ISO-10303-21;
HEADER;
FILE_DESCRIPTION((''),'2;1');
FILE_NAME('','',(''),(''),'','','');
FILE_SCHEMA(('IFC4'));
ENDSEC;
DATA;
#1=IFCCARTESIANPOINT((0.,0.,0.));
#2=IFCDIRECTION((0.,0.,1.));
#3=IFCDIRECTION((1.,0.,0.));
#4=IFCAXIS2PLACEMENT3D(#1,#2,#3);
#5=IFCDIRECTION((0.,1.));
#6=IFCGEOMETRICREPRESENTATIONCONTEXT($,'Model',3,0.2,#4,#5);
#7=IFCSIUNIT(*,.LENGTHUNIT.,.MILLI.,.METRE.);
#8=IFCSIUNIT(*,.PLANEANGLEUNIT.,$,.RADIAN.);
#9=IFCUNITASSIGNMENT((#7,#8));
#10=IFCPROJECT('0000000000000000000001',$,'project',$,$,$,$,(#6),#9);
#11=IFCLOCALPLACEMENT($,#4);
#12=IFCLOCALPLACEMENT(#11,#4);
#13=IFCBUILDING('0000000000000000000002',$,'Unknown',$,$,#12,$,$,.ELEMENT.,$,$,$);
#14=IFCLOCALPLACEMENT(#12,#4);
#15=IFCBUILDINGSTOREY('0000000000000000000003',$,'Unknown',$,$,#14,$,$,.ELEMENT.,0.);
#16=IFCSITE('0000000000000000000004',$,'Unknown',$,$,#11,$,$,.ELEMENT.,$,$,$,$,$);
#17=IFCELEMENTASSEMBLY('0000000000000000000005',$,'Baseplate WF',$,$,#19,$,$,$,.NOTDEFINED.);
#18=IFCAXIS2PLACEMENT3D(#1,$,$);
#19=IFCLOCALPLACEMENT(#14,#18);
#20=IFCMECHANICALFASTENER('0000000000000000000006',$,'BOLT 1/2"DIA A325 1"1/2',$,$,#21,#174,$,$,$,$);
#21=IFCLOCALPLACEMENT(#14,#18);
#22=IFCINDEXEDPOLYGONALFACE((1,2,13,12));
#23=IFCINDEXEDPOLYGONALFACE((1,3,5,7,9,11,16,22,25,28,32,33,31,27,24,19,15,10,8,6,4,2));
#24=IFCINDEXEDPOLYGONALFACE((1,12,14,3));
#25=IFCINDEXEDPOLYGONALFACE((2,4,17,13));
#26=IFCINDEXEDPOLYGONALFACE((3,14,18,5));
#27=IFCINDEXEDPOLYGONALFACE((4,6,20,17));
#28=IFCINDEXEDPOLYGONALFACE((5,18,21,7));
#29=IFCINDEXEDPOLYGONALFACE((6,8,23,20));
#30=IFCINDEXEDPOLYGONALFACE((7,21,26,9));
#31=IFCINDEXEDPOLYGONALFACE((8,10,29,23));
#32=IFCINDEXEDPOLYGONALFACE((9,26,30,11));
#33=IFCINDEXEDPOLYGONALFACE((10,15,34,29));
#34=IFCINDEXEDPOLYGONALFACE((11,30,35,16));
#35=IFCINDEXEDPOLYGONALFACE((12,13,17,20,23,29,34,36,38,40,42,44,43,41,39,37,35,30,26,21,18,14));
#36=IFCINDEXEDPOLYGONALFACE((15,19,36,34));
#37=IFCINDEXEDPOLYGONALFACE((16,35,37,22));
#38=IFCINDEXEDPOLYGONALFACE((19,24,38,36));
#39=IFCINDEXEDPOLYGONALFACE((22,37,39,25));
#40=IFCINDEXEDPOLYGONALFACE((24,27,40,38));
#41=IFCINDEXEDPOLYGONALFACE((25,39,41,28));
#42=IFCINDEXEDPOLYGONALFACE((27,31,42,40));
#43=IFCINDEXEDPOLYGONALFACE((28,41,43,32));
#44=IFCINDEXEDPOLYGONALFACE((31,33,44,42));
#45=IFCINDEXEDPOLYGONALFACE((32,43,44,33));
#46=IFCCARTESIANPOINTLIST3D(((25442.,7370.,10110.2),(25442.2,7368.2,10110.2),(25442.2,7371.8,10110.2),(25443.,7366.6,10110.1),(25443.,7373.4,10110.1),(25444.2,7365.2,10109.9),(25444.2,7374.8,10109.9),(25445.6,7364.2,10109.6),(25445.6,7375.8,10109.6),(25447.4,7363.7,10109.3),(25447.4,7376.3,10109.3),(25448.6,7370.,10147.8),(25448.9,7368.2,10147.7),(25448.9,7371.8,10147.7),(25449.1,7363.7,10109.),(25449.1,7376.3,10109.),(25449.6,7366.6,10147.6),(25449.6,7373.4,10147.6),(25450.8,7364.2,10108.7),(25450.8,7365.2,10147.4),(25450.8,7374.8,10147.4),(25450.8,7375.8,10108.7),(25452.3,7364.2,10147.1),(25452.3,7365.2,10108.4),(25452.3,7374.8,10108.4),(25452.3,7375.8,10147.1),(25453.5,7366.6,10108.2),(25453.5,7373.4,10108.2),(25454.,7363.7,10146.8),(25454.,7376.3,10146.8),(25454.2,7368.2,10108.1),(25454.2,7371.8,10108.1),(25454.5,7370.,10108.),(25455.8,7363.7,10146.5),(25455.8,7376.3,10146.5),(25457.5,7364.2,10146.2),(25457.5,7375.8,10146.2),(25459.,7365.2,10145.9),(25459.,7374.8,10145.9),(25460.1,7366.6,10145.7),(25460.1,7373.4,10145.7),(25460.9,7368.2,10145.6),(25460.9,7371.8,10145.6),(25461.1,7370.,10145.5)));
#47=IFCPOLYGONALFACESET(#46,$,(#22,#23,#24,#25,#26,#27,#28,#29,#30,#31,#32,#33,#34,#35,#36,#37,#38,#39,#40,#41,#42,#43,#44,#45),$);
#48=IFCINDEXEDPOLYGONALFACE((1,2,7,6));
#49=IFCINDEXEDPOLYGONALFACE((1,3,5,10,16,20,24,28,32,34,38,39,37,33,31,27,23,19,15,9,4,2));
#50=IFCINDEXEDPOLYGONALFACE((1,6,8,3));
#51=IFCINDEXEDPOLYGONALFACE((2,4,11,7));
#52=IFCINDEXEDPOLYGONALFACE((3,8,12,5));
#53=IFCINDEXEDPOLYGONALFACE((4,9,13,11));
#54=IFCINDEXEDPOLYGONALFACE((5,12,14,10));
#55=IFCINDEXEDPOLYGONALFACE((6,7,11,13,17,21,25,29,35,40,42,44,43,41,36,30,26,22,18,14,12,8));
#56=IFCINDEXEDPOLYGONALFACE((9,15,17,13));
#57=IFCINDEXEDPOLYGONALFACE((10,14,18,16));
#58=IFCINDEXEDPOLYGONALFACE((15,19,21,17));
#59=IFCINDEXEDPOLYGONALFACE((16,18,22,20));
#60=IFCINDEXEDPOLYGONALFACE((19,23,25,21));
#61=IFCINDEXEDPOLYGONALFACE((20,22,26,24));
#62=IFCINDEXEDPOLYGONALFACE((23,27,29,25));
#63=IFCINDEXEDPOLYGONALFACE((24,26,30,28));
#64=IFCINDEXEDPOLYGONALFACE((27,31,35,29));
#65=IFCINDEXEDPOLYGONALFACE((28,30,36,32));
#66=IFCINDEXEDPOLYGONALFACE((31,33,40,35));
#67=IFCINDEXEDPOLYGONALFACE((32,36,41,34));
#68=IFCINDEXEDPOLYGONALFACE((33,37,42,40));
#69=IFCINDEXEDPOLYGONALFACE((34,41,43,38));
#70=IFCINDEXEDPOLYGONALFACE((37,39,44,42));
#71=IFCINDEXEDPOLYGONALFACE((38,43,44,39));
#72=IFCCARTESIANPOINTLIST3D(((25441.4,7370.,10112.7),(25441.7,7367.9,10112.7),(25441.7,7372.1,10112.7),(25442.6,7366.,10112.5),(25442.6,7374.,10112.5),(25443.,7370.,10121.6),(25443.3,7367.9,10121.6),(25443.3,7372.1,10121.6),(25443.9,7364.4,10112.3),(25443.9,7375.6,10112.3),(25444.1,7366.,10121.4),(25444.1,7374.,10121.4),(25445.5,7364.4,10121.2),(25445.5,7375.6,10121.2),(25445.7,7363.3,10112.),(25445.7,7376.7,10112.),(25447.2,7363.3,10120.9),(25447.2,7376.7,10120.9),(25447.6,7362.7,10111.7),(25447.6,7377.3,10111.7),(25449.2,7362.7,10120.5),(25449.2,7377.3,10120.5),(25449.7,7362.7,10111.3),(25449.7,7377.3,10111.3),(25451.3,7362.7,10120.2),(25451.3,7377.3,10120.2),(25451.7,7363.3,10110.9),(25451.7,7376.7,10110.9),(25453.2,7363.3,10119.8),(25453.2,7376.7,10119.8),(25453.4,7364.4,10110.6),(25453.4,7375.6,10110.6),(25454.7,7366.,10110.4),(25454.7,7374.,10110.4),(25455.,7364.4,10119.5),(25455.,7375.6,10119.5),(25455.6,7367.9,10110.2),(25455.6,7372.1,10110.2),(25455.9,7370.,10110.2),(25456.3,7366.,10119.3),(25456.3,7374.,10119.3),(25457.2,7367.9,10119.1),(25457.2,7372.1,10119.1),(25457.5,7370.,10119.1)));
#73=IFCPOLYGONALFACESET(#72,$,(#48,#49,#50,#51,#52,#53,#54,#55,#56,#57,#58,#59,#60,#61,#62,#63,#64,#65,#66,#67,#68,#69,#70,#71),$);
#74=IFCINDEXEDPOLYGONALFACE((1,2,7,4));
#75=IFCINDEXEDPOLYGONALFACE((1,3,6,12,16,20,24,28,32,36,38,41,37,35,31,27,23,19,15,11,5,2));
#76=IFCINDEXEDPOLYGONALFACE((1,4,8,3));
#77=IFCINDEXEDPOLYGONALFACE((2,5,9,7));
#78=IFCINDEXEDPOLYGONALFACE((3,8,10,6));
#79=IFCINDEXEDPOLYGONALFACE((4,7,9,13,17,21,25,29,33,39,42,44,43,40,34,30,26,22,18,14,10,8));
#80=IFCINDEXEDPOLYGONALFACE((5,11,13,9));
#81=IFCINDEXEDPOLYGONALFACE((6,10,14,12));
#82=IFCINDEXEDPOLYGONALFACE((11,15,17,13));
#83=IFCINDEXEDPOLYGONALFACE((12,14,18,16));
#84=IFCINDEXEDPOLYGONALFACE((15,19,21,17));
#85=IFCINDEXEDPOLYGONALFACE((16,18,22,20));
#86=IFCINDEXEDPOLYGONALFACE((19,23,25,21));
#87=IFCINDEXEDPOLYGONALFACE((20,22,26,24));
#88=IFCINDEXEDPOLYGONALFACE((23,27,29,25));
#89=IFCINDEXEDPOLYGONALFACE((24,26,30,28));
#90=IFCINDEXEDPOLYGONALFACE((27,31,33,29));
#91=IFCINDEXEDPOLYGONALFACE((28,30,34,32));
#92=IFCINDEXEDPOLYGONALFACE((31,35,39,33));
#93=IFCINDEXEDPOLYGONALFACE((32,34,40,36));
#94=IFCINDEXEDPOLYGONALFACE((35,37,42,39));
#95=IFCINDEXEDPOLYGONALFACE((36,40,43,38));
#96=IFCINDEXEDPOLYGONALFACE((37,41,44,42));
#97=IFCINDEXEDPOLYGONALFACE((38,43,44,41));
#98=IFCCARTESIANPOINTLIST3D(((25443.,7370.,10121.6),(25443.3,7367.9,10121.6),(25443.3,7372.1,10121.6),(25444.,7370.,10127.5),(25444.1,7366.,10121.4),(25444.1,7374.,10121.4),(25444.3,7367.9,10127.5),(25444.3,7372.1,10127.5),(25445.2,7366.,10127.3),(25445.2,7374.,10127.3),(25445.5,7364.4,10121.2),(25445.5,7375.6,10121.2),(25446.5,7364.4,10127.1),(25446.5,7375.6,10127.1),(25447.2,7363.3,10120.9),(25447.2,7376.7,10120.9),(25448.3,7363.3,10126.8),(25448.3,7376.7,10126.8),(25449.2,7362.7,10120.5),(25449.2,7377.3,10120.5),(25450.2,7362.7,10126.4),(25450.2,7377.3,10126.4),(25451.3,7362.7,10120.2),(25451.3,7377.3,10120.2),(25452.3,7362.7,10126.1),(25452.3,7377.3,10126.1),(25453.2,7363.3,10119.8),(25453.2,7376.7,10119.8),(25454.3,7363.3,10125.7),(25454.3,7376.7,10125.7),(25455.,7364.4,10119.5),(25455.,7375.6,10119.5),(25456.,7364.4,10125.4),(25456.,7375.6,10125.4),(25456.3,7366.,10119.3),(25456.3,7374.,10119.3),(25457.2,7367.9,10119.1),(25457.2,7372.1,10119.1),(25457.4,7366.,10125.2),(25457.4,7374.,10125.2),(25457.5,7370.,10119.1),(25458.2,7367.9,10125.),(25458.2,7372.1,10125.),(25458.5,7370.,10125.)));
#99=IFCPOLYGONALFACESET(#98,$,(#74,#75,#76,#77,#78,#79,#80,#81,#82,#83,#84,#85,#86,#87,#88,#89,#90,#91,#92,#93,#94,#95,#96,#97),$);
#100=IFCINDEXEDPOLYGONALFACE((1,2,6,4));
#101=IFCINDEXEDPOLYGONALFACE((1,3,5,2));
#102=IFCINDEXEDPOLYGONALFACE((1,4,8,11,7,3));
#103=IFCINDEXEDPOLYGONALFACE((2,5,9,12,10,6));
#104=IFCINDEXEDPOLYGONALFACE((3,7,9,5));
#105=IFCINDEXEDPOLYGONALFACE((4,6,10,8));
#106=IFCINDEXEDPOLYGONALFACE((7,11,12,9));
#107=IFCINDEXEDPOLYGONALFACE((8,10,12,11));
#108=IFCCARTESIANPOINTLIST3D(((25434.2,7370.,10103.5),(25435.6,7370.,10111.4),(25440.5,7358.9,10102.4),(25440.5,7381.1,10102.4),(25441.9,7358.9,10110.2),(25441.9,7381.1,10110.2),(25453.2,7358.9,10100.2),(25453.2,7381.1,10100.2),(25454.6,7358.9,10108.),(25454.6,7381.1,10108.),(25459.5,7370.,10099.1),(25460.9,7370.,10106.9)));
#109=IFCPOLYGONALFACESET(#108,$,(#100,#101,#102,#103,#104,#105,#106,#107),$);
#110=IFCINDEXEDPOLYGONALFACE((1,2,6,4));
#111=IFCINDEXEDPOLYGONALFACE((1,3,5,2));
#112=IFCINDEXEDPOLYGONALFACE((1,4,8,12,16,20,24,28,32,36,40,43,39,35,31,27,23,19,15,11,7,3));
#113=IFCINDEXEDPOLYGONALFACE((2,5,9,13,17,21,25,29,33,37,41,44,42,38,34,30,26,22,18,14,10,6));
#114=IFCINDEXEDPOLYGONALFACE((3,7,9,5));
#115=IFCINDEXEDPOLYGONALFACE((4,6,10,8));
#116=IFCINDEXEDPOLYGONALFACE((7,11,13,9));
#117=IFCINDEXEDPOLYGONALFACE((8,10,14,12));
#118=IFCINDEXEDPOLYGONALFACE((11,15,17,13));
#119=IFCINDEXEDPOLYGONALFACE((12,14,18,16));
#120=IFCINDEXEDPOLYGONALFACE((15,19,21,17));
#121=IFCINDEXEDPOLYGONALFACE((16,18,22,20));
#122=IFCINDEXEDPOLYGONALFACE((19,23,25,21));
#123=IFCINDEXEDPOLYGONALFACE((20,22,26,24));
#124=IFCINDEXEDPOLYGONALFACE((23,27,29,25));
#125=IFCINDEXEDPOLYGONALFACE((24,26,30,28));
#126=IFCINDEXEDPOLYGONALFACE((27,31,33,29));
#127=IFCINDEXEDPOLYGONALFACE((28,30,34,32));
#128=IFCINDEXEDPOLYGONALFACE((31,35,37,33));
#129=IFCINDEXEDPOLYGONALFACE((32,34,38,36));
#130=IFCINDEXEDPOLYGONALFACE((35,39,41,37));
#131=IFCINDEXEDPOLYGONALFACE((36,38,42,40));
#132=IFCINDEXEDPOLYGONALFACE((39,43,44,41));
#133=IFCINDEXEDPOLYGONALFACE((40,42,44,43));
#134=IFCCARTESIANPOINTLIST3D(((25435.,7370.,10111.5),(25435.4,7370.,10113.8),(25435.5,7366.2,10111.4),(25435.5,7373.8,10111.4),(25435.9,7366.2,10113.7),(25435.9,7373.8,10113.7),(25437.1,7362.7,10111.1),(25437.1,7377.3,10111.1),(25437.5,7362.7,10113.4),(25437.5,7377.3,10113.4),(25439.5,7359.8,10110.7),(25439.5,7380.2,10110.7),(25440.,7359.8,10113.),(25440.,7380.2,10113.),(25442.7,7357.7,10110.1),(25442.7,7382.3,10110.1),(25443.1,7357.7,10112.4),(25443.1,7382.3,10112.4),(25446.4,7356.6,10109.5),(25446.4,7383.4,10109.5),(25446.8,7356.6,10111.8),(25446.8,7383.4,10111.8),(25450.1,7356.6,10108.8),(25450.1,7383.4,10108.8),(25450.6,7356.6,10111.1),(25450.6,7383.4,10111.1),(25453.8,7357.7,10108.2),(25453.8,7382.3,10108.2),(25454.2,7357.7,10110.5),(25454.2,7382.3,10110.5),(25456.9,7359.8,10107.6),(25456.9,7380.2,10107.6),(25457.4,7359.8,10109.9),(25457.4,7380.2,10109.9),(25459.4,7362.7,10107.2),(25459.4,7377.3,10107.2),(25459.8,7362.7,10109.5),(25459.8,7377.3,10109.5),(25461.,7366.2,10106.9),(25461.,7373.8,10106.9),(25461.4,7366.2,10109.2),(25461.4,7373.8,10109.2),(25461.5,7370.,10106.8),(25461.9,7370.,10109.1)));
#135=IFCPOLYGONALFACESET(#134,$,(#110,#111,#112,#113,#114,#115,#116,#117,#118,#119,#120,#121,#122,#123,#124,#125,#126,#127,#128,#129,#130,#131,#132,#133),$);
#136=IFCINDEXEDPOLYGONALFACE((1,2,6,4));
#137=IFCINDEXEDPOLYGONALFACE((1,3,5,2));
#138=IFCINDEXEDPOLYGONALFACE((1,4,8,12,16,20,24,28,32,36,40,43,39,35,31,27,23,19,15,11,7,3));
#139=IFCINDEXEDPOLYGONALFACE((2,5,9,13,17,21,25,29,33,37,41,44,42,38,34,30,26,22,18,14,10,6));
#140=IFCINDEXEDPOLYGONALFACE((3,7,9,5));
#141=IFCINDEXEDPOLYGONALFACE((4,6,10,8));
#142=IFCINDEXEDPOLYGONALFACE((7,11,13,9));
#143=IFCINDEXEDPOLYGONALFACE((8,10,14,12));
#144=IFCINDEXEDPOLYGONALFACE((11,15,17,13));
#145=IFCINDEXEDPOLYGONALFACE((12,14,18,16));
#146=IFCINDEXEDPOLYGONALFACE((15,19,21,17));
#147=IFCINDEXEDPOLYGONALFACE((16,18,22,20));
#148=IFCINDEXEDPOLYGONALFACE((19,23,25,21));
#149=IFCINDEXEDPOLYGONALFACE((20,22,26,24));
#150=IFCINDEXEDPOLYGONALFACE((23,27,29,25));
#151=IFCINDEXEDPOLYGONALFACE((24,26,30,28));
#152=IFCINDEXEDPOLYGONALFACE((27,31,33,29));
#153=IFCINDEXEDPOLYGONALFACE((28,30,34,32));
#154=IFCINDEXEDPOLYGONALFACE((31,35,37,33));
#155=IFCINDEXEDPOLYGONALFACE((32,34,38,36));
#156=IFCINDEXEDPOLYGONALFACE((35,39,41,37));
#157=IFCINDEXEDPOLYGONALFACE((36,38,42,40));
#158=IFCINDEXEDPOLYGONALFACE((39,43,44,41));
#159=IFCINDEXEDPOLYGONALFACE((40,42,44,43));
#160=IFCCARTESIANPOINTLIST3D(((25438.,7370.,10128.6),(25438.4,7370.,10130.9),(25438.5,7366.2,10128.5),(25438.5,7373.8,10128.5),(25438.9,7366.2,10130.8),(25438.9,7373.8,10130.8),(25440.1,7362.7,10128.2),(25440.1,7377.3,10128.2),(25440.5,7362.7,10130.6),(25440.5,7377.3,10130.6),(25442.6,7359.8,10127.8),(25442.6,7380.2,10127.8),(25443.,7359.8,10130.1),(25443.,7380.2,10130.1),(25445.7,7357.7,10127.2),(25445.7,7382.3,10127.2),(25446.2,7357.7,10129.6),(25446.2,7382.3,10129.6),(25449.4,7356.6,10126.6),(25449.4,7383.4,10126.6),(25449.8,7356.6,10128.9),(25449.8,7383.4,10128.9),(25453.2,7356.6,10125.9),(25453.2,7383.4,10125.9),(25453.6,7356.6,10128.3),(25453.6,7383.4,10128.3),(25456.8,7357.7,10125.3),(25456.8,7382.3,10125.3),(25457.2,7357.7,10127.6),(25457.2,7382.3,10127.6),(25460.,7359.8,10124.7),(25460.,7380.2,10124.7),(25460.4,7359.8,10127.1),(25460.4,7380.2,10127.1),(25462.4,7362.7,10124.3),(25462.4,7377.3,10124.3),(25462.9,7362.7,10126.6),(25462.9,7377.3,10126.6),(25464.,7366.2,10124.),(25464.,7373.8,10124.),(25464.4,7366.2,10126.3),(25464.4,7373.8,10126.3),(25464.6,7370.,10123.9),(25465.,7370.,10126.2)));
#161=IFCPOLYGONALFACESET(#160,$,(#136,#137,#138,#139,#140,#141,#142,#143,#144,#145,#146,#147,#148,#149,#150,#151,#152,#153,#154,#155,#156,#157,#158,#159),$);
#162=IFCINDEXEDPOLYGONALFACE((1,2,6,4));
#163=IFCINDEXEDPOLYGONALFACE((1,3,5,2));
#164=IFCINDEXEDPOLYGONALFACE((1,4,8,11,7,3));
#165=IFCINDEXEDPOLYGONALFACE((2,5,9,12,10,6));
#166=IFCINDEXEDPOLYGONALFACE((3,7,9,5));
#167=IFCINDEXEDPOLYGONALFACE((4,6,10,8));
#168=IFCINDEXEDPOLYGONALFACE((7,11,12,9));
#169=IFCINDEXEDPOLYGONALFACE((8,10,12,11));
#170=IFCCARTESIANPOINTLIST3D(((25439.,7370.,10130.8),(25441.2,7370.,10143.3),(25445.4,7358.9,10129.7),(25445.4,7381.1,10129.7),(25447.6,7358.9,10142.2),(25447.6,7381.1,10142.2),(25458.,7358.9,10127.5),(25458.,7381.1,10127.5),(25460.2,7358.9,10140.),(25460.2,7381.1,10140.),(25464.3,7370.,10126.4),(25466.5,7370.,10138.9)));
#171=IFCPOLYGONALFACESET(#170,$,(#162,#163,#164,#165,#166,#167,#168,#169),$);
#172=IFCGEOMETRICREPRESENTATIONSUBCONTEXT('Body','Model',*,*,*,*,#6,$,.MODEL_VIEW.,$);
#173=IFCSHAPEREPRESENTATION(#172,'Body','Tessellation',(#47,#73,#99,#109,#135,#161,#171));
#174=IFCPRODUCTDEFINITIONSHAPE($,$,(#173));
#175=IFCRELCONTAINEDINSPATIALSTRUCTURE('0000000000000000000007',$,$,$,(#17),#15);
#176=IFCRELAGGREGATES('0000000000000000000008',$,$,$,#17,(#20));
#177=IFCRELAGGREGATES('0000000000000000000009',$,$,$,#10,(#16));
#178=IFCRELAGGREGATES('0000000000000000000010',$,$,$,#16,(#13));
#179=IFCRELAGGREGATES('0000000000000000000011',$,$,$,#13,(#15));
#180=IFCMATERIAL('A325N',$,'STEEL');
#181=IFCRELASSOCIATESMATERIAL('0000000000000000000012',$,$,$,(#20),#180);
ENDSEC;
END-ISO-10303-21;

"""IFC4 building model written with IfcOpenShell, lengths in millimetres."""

from ifc_helpers import new_model, si_unit, direction, frame, origin_with_axes, place, context, subcontext, project, spatial, line, arc, indexed_curve, outline, extrude, source, transform, mapped, material, element, aggregate, save


model = new_model("IFC4")

# Units and contexts
model_context = context("Model", 3, precision=0.2, world=origin_with_axes(), true_north=direction((0.0, 1.0)))
body_context = subcontext(model_context, "Body", "Model", "MODEL_VIEW")
ifc_project = project(units=[si_unit("LENGTHUNIT", "METRE", prefix="MILLI"), si_unit("PLANEANGLEUNIT", "RADIAN")], contexts=[model_context])

# Site, building, storey
site_placement = place(None, origin_with_axes())
site = spatial("IfcSite", under=ifc_project, at=site_placement, Name="Unknown", CompositionType="ELEMENT")
building_placement = place(site_placement, origin_with_axes())
building = spatial("IfcBuilding", under=site, at=building_placement, Name="Unknown", CompositionType="ELEMENT")
storey_placement = place(building_placement, origin_with_axes())
storey = spatial("IfcBuildingStorey", under=building, at=storey_placement, Name="Unknown", CompositionType="ELEMENT", Elevation=0.0)

# Element assembly
assembly_1_placement = place(storey_placement, frame((25480.3, 7400.0, 10118.1), z_axis=(-0.173648, 0.0, -0.984808), x_axis=(0.0, -1.0, 0.0)))
assembly_1 = element("IfcElementAssembly", 1, at=assembly_1_placement, inside=storey, Name="Baseplate WF", PredefinedType="NOTDEFINED")

# Mechanical fastener
ifc_material_1 = material(Name="A325N", Category="STEEL")
shared_shape_1 = source(origin_with_axes(), body_context, "Body", "SweptSolid", [
    extrude(outline(indexed_curve([(6.3, 0.0), (0.0, 6.3), (-6.3, 0.0), (0.0, -6.3)], segments=[arc(1, 2, 3), arc(3, 4, 1)])), frame((0.0, 0.0, 17.4), z_axis=(0.0, 0.0, -1.0), x_axis=(0.0, 1.0, 0.0)), (0.0, 0.0, 1.0), 38.1),
    extrude(outline(indexed_curve([(7.3, 0.0), (0.0, 7.3), (-7.3, 0.0), (0.0, -7.3)], segments=[arc(1, 2, 3), arc(3, 4, 1)])), frame((0.0, 0.0, 15.0), z_axis=(0.0, 0.0, -1.0), x_axis=(0.0, 1.0, 0.0)), (0.0, 0.0, 1.0), 9.0),
    extrude(outline(indexed_curve([(7.3, 0.0), (0.0, 7.3), (-7.3, 0.0), (0.0, -7.3)], segments=[arc(1, 2, 3), arc(3, 4, 1)])), frame((0.0, 0.0, 6.0), z_axis=(0.0, 0.0, -1.0), x_axis=(0.0, 1.0, 0.0)), (0.0, 0.0, 1.0), 6.0),
    extrude(outline(indexed_curve([(12.8, 0.0), (6.4, 11.1), (-6.4, 11.1), (-12.8, 0.0), (-6.4, -11.1), (6.4, -11.1)], segments=[line(1, 2, 3, 4, 5, 6, 1)])), frame((0.0, 0.0, 25.3), z_axis=(0.0, 0.0, -1.0), x_axis=(0.0, 1.0, 0.0)), (0.0, 0.0, 1.0), 7.9),
    extrude(outline(indexed_curve([(13.5, 0.0), (0.0, 13.5), (-13.5, 0.0), (0.0, -13.5)], segments=[arc(1, 2, 3), arc(3, 4, 1)])), frame((0.0, 0.0, 17.4), z_axis=(0.0, 0.0, -1.0), x_axis=(0.0, 1.0, 0.0)), (0.0, 0.0, 1.0), 2.4),
    extrude(outline(indexed_curve([(13.5, 0.0), (0.0, 13.5), (-13.5, 0.0), (0.0, -13.5)], segments=[arc(1, 2, 3), arc(3, 4, 1)])), frame((0.0, 0.0, 0.0), z_axis=(0.0, 0.0, -1.0), x_axis=(0.0, 1.0, 0.0)), (0.0, 0.0, 1.0), 2.4),
    extrude(outline(indexed_curve([(12.8, 0.0), (6.4, 11.1), (-6.4, 11.1), (-12.8, 0.0), (-6.4, -11.1), (6.4, -11.1)], segments=[line(1, 2, 3, 4, 5, 6, 1)])), frame((0.0, 0.0, -2.4), z_axis=(0.0, 0.0, -1.0), x_axis=(0.0, 1.0, 0.0)), (0.0, 0.0, 1.0), 12.7),
])
mechanical_fastener_1_placement = place(assembly_1_placement, frame((30.0, 30.0, -3.0), z_axis=(0.0, 0.0, 1.0), x_axis=(1.0, 0.0, 0.0)))
mechanical_fastener_1 = element("IfcMechanicalFastener", 2, at=mechanical_fastener_1_placement, material=ifc_material_1, Name="BOLT 1/2\"DIA A325 1\"1/2", context=body_context, shape_type="MappedRepresentation", body=[
    mapped(shared_shape_1, transform((0.0, 0.0, 0.0))),
])
aggregate(assembly_1, [mechanical_fastener_1])

save(model, "model.ifc")
